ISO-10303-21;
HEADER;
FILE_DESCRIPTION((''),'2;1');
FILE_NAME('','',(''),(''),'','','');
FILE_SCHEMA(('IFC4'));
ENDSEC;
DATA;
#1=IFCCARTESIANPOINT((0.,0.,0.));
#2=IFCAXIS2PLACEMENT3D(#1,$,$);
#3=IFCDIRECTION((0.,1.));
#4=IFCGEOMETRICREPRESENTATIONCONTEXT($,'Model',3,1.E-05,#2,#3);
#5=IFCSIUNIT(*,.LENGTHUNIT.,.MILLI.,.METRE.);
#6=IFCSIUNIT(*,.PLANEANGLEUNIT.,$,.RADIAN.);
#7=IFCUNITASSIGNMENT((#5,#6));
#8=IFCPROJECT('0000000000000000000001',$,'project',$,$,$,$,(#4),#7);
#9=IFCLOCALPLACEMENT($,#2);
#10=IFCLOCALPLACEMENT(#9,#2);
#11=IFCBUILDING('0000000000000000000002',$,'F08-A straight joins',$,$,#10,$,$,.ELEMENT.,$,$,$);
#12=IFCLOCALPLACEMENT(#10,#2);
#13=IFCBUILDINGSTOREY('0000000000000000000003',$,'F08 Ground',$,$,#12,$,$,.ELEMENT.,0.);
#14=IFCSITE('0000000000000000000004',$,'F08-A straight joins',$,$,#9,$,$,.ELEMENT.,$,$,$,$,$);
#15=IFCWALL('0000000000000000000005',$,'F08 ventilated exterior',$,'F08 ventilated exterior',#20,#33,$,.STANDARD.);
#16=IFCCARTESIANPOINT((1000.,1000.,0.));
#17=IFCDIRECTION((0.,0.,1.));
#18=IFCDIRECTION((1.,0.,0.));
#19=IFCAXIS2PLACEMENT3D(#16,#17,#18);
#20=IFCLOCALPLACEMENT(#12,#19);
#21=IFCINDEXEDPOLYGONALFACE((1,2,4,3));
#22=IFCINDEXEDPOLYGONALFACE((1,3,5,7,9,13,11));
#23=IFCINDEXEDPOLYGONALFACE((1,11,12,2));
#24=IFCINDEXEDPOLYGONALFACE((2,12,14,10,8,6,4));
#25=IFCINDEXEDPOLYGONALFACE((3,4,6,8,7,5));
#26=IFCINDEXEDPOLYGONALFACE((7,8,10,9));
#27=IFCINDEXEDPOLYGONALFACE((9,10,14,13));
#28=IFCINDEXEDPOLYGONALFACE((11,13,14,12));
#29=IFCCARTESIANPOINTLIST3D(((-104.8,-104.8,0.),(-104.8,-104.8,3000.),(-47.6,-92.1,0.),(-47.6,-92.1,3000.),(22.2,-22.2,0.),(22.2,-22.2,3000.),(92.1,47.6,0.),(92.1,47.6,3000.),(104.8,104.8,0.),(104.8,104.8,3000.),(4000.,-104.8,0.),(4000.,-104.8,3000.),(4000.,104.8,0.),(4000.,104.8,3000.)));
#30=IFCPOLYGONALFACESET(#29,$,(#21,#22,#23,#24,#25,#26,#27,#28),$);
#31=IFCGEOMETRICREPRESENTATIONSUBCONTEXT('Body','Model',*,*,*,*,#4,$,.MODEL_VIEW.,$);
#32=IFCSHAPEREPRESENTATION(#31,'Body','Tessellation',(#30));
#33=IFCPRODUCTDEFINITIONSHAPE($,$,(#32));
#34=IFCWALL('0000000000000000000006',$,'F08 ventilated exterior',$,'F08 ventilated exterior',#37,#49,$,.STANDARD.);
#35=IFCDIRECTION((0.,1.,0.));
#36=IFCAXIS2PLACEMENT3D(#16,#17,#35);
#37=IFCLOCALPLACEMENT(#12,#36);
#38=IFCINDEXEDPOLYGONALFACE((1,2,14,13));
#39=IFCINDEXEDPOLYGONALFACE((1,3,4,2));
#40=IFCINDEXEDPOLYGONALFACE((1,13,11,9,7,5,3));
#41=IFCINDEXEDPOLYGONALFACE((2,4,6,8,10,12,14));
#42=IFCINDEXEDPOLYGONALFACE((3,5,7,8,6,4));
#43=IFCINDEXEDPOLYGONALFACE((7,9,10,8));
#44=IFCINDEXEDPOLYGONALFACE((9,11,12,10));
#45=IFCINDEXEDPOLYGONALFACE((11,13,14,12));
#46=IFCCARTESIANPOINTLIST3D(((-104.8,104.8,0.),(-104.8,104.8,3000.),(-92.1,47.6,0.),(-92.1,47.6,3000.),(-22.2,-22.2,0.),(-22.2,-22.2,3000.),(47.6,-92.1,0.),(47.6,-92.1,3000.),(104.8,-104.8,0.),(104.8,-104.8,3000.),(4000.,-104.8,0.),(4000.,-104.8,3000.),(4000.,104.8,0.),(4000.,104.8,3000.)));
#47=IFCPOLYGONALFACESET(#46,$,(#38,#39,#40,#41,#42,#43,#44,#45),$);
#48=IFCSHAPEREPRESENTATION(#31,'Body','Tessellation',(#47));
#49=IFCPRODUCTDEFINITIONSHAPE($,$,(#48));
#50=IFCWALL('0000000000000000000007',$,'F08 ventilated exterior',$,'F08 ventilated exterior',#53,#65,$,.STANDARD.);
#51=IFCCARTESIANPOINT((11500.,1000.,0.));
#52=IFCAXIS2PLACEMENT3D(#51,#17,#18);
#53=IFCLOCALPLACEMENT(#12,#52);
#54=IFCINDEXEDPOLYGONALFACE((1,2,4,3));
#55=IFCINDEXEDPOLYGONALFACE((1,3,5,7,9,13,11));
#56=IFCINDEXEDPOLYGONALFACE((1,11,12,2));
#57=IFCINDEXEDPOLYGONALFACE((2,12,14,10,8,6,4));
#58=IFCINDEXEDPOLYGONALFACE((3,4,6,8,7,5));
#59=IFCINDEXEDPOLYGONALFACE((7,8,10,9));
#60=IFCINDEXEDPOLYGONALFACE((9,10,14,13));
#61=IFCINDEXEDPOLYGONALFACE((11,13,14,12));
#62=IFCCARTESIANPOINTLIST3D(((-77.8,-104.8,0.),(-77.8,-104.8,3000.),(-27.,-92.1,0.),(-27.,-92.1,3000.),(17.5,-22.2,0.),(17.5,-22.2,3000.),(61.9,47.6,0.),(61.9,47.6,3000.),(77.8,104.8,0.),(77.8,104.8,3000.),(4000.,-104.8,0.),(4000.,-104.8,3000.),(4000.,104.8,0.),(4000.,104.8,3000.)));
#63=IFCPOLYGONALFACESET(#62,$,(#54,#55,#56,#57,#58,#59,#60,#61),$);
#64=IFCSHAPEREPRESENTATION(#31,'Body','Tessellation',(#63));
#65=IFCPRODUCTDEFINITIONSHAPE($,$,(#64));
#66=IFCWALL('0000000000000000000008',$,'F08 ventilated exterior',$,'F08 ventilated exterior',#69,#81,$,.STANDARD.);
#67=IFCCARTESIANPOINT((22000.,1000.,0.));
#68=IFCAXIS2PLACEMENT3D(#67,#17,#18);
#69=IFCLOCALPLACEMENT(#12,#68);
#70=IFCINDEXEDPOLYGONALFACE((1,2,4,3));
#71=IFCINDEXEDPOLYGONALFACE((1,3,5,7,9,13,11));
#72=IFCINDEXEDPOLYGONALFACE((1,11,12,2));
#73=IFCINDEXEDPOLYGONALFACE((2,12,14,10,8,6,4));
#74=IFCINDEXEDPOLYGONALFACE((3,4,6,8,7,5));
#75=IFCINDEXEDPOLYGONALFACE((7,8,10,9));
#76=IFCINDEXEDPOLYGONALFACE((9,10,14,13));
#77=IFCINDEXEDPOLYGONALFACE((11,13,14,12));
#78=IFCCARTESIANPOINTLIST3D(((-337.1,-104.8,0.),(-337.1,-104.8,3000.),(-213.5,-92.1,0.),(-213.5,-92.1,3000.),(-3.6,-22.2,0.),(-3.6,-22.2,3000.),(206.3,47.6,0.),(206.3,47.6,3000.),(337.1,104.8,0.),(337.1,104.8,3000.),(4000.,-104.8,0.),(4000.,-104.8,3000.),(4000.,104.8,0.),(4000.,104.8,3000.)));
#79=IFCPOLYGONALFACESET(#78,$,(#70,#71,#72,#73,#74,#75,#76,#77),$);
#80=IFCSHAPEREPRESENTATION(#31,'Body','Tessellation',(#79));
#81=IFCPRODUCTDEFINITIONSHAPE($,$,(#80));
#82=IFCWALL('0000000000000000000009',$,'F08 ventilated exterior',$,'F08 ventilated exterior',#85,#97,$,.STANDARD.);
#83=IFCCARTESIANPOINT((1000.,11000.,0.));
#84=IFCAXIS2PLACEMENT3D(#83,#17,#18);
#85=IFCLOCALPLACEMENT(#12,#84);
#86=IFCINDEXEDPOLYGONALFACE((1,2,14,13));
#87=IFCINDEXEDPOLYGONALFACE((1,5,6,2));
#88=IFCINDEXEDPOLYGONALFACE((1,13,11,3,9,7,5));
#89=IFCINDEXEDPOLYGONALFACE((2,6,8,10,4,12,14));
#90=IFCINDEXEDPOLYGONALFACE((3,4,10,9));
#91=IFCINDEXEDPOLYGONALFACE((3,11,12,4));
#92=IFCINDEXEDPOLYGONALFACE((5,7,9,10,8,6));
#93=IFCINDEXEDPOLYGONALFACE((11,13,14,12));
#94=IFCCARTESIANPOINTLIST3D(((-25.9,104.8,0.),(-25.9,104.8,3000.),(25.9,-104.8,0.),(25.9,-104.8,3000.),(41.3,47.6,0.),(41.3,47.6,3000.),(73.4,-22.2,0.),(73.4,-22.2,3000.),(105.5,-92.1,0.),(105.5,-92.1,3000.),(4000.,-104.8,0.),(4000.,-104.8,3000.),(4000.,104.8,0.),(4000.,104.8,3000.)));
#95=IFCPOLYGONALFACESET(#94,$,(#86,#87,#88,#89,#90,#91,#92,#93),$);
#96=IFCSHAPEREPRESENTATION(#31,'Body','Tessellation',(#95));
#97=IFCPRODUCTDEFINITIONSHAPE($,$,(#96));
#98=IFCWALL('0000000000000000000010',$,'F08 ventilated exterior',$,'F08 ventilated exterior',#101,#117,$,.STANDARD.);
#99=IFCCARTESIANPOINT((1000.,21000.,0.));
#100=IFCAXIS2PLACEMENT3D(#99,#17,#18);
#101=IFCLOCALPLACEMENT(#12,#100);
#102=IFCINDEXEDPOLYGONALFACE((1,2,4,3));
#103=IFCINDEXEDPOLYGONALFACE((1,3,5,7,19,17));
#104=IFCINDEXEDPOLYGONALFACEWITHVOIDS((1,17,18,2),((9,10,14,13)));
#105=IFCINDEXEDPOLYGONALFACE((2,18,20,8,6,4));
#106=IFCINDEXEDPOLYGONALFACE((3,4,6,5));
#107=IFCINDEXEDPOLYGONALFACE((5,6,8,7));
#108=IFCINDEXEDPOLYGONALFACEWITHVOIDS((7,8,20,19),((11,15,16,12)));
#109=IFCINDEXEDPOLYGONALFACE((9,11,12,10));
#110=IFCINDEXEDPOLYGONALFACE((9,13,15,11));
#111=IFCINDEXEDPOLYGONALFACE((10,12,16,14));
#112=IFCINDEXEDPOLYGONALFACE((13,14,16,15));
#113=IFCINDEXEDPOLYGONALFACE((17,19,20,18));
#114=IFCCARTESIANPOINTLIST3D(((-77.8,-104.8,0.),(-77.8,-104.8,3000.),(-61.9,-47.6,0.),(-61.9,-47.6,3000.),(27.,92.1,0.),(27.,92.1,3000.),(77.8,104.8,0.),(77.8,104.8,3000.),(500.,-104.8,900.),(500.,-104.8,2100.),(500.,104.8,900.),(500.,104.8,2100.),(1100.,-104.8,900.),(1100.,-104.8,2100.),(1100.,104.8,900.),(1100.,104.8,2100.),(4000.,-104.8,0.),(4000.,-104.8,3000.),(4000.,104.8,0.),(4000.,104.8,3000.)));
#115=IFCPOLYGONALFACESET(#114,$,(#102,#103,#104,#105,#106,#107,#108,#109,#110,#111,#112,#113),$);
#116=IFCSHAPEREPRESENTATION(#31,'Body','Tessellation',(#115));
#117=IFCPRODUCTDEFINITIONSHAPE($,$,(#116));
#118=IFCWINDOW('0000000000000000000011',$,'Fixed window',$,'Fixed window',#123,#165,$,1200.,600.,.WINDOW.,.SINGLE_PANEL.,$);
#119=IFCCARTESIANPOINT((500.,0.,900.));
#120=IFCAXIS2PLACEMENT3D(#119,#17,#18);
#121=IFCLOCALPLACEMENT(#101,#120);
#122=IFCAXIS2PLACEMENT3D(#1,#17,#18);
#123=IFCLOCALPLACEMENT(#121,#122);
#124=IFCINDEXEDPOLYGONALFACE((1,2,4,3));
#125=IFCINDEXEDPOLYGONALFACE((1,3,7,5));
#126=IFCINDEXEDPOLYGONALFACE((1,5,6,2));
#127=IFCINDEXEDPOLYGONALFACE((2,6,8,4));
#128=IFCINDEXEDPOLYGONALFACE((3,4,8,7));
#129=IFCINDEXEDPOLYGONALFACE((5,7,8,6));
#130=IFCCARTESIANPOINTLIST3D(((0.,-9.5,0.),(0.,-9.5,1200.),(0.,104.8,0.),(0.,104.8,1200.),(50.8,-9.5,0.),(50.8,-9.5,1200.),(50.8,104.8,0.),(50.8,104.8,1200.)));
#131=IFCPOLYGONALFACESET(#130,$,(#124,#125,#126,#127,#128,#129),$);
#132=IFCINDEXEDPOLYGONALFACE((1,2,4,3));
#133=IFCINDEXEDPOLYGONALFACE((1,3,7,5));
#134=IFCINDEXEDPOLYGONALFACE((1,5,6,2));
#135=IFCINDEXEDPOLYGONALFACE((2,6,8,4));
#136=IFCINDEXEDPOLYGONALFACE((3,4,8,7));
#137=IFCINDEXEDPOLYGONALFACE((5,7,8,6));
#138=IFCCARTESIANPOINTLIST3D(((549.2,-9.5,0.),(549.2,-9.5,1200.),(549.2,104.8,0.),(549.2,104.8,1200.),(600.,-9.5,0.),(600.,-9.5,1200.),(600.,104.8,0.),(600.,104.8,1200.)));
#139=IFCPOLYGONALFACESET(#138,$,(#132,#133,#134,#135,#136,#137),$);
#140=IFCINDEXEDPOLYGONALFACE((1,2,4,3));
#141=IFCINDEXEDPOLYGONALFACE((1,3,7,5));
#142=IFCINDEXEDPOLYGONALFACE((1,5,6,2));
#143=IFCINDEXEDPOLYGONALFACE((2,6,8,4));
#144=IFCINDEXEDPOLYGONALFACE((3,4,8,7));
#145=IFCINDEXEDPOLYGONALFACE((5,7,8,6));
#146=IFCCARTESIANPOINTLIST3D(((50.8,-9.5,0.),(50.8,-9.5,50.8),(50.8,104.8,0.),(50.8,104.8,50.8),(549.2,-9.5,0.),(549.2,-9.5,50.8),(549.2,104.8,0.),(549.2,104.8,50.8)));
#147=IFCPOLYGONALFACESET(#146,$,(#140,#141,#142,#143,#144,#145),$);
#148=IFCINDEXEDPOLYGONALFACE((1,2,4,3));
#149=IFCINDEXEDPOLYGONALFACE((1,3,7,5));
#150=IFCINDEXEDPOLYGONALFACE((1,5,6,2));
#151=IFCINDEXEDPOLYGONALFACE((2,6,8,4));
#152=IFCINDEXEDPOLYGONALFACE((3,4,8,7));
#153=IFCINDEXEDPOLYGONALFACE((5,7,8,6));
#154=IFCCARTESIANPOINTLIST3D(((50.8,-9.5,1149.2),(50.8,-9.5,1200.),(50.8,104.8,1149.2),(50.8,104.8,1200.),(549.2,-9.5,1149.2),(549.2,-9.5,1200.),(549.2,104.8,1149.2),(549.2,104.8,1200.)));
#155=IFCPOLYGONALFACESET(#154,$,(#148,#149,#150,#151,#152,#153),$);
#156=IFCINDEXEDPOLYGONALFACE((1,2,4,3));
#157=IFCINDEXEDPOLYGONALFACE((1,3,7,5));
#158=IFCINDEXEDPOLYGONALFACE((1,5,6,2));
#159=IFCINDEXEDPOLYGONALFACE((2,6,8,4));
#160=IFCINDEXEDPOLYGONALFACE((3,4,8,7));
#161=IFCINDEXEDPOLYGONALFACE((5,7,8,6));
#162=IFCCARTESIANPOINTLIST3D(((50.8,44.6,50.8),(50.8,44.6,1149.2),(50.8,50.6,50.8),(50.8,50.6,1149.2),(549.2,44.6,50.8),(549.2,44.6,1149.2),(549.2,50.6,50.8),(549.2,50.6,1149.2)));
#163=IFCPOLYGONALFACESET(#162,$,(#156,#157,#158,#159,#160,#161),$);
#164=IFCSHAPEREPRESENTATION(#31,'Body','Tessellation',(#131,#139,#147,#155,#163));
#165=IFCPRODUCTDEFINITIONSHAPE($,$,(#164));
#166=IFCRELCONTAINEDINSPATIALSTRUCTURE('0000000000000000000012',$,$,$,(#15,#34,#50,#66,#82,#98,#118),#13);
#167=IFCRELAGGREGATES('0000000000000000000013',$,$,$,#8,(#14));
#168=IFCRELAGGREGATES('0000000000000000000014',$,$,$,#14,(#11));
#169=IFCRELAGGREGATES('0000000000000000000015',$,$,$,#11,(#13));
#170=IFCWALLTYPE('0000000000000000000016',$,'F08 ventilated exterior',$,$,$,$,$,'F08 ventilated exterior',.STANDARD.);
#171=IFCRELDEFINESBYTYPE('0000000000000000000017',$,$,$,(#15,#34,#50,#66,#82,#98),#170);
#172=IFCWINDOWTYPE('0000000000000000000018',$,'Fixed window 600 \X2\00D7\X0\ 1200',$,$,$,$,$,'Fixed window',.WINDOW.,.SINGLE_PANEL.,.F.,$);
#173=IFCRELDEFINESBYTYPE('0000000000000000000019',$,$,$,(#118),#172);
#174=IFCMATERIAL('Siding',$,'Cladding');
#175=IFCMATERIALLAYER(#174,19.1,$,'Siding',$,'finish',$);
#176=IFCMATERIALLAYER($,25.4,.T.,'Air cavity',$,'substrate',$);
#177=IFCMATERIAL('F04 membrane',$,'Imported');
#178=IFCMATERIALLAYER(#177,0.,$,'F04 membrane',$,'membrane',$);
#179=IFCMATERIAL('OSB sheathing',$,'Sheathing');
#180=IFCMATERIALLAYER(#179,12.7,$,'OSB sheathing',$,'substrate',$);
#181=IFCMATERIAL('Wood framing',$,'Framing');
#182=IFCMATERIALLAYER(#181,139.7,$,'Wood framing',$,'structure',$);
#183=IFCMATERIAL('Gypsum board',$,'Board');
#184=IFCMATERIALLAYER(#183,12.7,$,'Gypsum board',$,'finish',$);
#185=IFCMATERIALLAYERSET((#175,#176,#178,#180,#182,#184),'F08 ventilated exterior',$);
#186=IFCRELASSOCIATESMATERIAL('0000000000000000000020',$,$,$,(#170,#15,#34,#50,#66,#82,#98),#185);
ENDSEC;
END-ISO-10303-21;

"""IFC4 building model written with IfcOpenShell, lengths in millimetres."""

from ifc_helpers import new_model, si_unit, direction, frame, origin, origin_with_axes, place, context, subcontext, project, spatial, polyline, outline, extrude, material, layer, layer_set, layer_usage, type_object, element, fill, save


model = new_model("IFC4")

# Units and contexts
model_context = context("Model", 3, precision=1e-05, world=origin(), true_north=direction((0.0, 1.0)))
body_context = subcontext(model_context, "Body", "Model", "MODEL_VIEW")
ifc_project = project(units=[si_unit("LENGTHUNIT", "METRE", prefix="MILLI"), si_unit("PLANEANGLEUNIT", "RADIAN")], contexts=[model_context])

# Site, building, storey
site_placement = place(None, origin())
site = spatial("IfcSite", under=ifc_project, at=site_placement, Name="F08-A straight joins", CompositionType="ELEMENT")
building_placement = place(site_placement, origin())
building = spatial("IfcBuilding", under=site, at=building_placement, Name="F08-A straight joins", CompositionType="ELEMENT")
storey_placement = place(building_placement, origin())
storey = spatial("IfcBuildingStorey", under=building, at=storey_placement, Name="F08 Ground", CompositionType="ELEMENT", Elevation=0.0)

# Walls
ifc_material_1 = material(Name="Siding", Category="Cladding")
ifc_layer_1 = layer(ifc_material_1, 19.1, Name="Siding", Category="finish")
ifc_layer_2 = layer(None, 25.4, ventilated=True, Name="Air cavity", Category="substrate")
ifc_material_2 = material(Name="F04 membrane", Category="Imported")
ifc_layer_3 = layer(ifc_material_2, 0.0, Name="F04 membrane", Category="membrane")
ifc_material_3 = material(Name="OSB sheathing", Category="Sheathing")
ifc_layer_4 = layer(ifc_material_3, 12.7, Name="OSB sheathing", Category="substrate")
ifc_material_4 = material(Name="Wood framing", Category="Framing")
ifc_layer_5 = layer(ifc_material_4, 139.7, Name="Wood framing", Category="structure")
ifc_material_5 = material(Name="Gypsum board", Category="Board")
ifc_layer_6 = layer(ifc_material_5, 12.7, Name="Gypsum board", Category="finish")
ifc_layer_set_1 = layer_set([ifc_layer_1, ifc_layer_2, ifc_layer_3, ifc_layer_4, ifc_layer_5, ifc_layer_6], Name="F08 ventilated exterior")
ifc_layer_usage_1 = layer_usage(ifc_layer_set_1, "AXIS2", "NEGATIVE", 104.8)
wall_type_1 = type_object("IfcWallType", Name="F08 ventilated exterior", ElementType="F08 ventilated exterior", PredefinedType="STANDARD", material=ifc_layer_set_1)
wall_1_placement = place(storey_placement, frame((1000.0, 1000.0, 0.0), z_axis=(0.0, 0.0, 1.0), x_axis=(1.0, 0.0, 0.0)))
element("IfcWall", 1, at=wall_1_placement, inside=storey, type_object=wall_type_1, material=ifc_layer_usage_1, Name="F08 ventilated exterior", ObjectType="F08 ventilated exterior", PredefinedType="STANDARD", context=body_context, shape_type="SweptSolid", body=[
    extrude(outline(polyline([(-104.8, -104.8), (4000.0, -104.8), (4000.0, 104.8), (104.8, 104.8), (92.1, 47.6), (22.2, -22.2), (-47.6, -92.1), (-104.8, -104.8)])), origin(), (0.0, 0.0, 1.0), 3000.0),
])
ifc_layer_usage_2 = layer_usage(ifc_layer_set_1, "AXIS2", "NEGATIVE", 104.8)
wall_2_placement = place(storey_placement, frame((1000.0, 1000.0, 0.0), z_axis=(0.0, 0.0, 1.0), x_axis=(0.0, 1.0, 0.0)))
element("IfcWall", 2, at=wall_2_placement, inside=storey, type_object=wall_type_1, material=ifc_layer_usage_2, Name="F08 ventilated exterior", ObjectType="F08 ventilated exterior", PredefinedType="STANDARD", context=body_context, shape_type="SweptSolid", body=[
    extrude(outline(polyline([(104.8, -104.8), (4000.0, -104.8), (4000.0, 104.8), (-104.8, 104.8), (-92.1, 47.6), (-22.2, -22.2), (47.6, -92.1), (104.8, -104.8)])), origin(), (0.0, 0.0, 1.0), 3000.0),
])
ifc_layer_usage_3 = layer_usage(ifc_layer_set_1, "AXIS2", "NEGATIVE", 104.8)
wall_3_placement = place(storey_placement, frame((11500.0, 1000.0, 0.0), z_axis=(0.0, 0.0, 1.0), x_axis=(1.0, 0.0, 0.0)))
element("IfcWall", 3, at=wall_3_placement, inside=storey, type_object=wall_type_1, material=ifc_layer_usage_3, Name="F08 ventilated exterior", ObjectType="F08 ventilated exterior", PredefinedType="STANDARD", context=body_context, shape_type="SweptSolid", body=[
    extrude(outline(polyline([(-77.8, -104.8), (4000.0, -104.8), (4000.0, 104.8), (77.8, 104.8), (61.9, 47.6), (17.5, -22.2), (-27.0, -92.1), (-77.8, -104.8)])), origin(), (0.0, 0.0, 1.0), 3000.0),
])
ifc_layer_usage_4 = layer_usage(ifc_layer_set_1, "AXIS2", "NEGATIVE", 104.8)
wall_4_placement = place(storey_placement, frame((22000.0, 1000.0, 0.0), z_axis=(0.0, 0.0, 1.0), x_axis=(1.0, 0.0, 0.0)))
element("IfcWall", 4, at=wall_4_placement, inside=storey, type_object=wall_type_1, material=ifc_layer_usage_4, Name="F08 ventilated exterior", ObjectType="F08 ventilated exterior", PredefinedType="STANDARD", context=body_context, shape_type="SweptSolid", body=[
    extrude(outline(polyline([(-337.1, -104.8), (4000.0, -104.8), (4000.0, 104.8), (337.1, 104.8), (206.3, 47.6), (-3.6, -22.2), (-213.5, -92.1), (-337.1, -104.8)])), origin(), (0.0, 0.0, 1.0), 3000.0),
])
ifc_layer_usage_5 = layer_usage(ifc_layer_set_1, "AXIS2", "NEGATIVE", 104.8)
wall_5_placement = place(storey_placement, frame((1000.0, 11000.0, 0.0), z_axis=(0.0, 0.0, 1.0), x_axis=(1.0, 0.0, 0.0)))
element("IfcWall", 5, at=wall_5_placement, inside=storey, type_object=wall_type_1, material=ifc_layer_usage_5, Name="F08 ventilated exterior", ObjectType="F08 ventilated exterior", PredefinedType="STANDARD", context=body_context, shape_type="SweptSolid", body=[
    extrude(outline(polyline([(25.9, -104.8), (4000.0, -104.8), (4000.0, 104.8), (-25.9, 104.8), (41.3, 47.6), (73.4, -22.2), (105.5, -92.1), (25.9, -104.8)])), origin(), (0.0, 0.0, 1.0), 3000.0),
])

# Wall, opening, window
ifc_layer_usage_6 = layer_usage(ifc_layer_set_1, "AXIS2", "POSITIVE", -104.8)
wall_6_placement = place(storey_placement, frame((1000.0, 21000.0, 0.0), z_axis=(0.0, 0.0, 1.0), x_axis=(1.0, 0.0, 0.0)))
wall_6 = element("IfcWall", 6, at=wall_6_placement, inside=storey, type_object=wall_type_1, material=ifc_layer_usage_6, Name="F08 ventilated exterior", ObjectType="F08 ventilated exterior", PredefinedType="STANDARD", context=body_context, shape_type="SweptSolid", body=[
    extrude(outline(polyline([(-77.8, -104.8), (4000.0, -104.8), (4000.0, 104.8), (77.8, 104.8), (27.0, 92.1), (-17.5, 22.2), (-61.9, -47.6), (-77.8, -104.8)])), origin(), (0.0, 0.0, 1.0), 3000.0),
])
opening_placement = place(wall_6_placement, frame((500.0, 0.0, 900.0), z_axis=(0.0, 0.0, 1.0), x_axis=(1.0, 0.0, 0.0)))
opening = element("IfcOpeningElement", 7, at=opening_placement, cuts=wall_6, PredefinedType="OPENING", context=body_context, shape_type="SweptSolid", body=[
    extrude(outline(polyline([(0.0, -114.8), (600.0, -114.8), (600.0, 114.8), (0.0, 114.8), (0.0, -114.8)])), origin(), (0.0, 0.0, 1.0), 1200.0),
])
window_type = type_object("IfcWindowType", Name="Fixed window 600 × 1200", ElementType="Fixed window", ParameterTakesPrecedence=False, PartitioningType="SINGLE_PANEL", PredefinedType="WINDOW")
window_placement = place(opening_placement, origin_with_axes())
window = element("IfcWindow", 8, at=window_placement, inside=storey, type_object=window_type, Name="Fixed window", ObjectType="Fixed window", OverallHeight=1200.0, OverallWidth=600.0, PartitioningType="SINGLE_PANEL", PredefinedType="WINDOW", context=body_context, shape_type="SweptSolid", body=[
    extrude(outline(polyline([(0.0, -9.5), (50.8, -9.5), (50.8, 104.8), (0.0, 104.8), (0.0, -9.5)])), origin(), (0.0, 0.0, 1.0), 1200.0),
    extrude(outline(polyline([(549.2, -9.5), (600.0, -9.5), (600.0, 104.8), (549.2, 104.8), (549.2, -9.5)])), origin(), (0.0, 0.0, 1.0), 1200.0),
    extrude(outline(polyline([(50.8, -9.5), (549.2, -9.5), (549.2, 104.8), (50.8, 104.8), (50.8, -9.5)])), origin(), (0.0, 0.0, 1.0), 50.8),
    extrude(outline(polyline([(50.8, -9.5), (549.2, -9.5), (549.2, 104.8), (50.8, 104.8), (50.8, -9.5)])), frame((0.0, 0.0, 1149.2)), (0.0, 0.0, 1.0), 50.8),
    extrude(outline(polyline([(50.8, 44.6), (549.2, 44.6), (549.2, 50.6), (50.8, 50.6), (50.8, 44.6)])), frame((0.0, 0.0, 50.8)), (0.0, 0.0, 1.0), 1098.4),
])
fill(opening, window)

save(model, "model.ifc")
